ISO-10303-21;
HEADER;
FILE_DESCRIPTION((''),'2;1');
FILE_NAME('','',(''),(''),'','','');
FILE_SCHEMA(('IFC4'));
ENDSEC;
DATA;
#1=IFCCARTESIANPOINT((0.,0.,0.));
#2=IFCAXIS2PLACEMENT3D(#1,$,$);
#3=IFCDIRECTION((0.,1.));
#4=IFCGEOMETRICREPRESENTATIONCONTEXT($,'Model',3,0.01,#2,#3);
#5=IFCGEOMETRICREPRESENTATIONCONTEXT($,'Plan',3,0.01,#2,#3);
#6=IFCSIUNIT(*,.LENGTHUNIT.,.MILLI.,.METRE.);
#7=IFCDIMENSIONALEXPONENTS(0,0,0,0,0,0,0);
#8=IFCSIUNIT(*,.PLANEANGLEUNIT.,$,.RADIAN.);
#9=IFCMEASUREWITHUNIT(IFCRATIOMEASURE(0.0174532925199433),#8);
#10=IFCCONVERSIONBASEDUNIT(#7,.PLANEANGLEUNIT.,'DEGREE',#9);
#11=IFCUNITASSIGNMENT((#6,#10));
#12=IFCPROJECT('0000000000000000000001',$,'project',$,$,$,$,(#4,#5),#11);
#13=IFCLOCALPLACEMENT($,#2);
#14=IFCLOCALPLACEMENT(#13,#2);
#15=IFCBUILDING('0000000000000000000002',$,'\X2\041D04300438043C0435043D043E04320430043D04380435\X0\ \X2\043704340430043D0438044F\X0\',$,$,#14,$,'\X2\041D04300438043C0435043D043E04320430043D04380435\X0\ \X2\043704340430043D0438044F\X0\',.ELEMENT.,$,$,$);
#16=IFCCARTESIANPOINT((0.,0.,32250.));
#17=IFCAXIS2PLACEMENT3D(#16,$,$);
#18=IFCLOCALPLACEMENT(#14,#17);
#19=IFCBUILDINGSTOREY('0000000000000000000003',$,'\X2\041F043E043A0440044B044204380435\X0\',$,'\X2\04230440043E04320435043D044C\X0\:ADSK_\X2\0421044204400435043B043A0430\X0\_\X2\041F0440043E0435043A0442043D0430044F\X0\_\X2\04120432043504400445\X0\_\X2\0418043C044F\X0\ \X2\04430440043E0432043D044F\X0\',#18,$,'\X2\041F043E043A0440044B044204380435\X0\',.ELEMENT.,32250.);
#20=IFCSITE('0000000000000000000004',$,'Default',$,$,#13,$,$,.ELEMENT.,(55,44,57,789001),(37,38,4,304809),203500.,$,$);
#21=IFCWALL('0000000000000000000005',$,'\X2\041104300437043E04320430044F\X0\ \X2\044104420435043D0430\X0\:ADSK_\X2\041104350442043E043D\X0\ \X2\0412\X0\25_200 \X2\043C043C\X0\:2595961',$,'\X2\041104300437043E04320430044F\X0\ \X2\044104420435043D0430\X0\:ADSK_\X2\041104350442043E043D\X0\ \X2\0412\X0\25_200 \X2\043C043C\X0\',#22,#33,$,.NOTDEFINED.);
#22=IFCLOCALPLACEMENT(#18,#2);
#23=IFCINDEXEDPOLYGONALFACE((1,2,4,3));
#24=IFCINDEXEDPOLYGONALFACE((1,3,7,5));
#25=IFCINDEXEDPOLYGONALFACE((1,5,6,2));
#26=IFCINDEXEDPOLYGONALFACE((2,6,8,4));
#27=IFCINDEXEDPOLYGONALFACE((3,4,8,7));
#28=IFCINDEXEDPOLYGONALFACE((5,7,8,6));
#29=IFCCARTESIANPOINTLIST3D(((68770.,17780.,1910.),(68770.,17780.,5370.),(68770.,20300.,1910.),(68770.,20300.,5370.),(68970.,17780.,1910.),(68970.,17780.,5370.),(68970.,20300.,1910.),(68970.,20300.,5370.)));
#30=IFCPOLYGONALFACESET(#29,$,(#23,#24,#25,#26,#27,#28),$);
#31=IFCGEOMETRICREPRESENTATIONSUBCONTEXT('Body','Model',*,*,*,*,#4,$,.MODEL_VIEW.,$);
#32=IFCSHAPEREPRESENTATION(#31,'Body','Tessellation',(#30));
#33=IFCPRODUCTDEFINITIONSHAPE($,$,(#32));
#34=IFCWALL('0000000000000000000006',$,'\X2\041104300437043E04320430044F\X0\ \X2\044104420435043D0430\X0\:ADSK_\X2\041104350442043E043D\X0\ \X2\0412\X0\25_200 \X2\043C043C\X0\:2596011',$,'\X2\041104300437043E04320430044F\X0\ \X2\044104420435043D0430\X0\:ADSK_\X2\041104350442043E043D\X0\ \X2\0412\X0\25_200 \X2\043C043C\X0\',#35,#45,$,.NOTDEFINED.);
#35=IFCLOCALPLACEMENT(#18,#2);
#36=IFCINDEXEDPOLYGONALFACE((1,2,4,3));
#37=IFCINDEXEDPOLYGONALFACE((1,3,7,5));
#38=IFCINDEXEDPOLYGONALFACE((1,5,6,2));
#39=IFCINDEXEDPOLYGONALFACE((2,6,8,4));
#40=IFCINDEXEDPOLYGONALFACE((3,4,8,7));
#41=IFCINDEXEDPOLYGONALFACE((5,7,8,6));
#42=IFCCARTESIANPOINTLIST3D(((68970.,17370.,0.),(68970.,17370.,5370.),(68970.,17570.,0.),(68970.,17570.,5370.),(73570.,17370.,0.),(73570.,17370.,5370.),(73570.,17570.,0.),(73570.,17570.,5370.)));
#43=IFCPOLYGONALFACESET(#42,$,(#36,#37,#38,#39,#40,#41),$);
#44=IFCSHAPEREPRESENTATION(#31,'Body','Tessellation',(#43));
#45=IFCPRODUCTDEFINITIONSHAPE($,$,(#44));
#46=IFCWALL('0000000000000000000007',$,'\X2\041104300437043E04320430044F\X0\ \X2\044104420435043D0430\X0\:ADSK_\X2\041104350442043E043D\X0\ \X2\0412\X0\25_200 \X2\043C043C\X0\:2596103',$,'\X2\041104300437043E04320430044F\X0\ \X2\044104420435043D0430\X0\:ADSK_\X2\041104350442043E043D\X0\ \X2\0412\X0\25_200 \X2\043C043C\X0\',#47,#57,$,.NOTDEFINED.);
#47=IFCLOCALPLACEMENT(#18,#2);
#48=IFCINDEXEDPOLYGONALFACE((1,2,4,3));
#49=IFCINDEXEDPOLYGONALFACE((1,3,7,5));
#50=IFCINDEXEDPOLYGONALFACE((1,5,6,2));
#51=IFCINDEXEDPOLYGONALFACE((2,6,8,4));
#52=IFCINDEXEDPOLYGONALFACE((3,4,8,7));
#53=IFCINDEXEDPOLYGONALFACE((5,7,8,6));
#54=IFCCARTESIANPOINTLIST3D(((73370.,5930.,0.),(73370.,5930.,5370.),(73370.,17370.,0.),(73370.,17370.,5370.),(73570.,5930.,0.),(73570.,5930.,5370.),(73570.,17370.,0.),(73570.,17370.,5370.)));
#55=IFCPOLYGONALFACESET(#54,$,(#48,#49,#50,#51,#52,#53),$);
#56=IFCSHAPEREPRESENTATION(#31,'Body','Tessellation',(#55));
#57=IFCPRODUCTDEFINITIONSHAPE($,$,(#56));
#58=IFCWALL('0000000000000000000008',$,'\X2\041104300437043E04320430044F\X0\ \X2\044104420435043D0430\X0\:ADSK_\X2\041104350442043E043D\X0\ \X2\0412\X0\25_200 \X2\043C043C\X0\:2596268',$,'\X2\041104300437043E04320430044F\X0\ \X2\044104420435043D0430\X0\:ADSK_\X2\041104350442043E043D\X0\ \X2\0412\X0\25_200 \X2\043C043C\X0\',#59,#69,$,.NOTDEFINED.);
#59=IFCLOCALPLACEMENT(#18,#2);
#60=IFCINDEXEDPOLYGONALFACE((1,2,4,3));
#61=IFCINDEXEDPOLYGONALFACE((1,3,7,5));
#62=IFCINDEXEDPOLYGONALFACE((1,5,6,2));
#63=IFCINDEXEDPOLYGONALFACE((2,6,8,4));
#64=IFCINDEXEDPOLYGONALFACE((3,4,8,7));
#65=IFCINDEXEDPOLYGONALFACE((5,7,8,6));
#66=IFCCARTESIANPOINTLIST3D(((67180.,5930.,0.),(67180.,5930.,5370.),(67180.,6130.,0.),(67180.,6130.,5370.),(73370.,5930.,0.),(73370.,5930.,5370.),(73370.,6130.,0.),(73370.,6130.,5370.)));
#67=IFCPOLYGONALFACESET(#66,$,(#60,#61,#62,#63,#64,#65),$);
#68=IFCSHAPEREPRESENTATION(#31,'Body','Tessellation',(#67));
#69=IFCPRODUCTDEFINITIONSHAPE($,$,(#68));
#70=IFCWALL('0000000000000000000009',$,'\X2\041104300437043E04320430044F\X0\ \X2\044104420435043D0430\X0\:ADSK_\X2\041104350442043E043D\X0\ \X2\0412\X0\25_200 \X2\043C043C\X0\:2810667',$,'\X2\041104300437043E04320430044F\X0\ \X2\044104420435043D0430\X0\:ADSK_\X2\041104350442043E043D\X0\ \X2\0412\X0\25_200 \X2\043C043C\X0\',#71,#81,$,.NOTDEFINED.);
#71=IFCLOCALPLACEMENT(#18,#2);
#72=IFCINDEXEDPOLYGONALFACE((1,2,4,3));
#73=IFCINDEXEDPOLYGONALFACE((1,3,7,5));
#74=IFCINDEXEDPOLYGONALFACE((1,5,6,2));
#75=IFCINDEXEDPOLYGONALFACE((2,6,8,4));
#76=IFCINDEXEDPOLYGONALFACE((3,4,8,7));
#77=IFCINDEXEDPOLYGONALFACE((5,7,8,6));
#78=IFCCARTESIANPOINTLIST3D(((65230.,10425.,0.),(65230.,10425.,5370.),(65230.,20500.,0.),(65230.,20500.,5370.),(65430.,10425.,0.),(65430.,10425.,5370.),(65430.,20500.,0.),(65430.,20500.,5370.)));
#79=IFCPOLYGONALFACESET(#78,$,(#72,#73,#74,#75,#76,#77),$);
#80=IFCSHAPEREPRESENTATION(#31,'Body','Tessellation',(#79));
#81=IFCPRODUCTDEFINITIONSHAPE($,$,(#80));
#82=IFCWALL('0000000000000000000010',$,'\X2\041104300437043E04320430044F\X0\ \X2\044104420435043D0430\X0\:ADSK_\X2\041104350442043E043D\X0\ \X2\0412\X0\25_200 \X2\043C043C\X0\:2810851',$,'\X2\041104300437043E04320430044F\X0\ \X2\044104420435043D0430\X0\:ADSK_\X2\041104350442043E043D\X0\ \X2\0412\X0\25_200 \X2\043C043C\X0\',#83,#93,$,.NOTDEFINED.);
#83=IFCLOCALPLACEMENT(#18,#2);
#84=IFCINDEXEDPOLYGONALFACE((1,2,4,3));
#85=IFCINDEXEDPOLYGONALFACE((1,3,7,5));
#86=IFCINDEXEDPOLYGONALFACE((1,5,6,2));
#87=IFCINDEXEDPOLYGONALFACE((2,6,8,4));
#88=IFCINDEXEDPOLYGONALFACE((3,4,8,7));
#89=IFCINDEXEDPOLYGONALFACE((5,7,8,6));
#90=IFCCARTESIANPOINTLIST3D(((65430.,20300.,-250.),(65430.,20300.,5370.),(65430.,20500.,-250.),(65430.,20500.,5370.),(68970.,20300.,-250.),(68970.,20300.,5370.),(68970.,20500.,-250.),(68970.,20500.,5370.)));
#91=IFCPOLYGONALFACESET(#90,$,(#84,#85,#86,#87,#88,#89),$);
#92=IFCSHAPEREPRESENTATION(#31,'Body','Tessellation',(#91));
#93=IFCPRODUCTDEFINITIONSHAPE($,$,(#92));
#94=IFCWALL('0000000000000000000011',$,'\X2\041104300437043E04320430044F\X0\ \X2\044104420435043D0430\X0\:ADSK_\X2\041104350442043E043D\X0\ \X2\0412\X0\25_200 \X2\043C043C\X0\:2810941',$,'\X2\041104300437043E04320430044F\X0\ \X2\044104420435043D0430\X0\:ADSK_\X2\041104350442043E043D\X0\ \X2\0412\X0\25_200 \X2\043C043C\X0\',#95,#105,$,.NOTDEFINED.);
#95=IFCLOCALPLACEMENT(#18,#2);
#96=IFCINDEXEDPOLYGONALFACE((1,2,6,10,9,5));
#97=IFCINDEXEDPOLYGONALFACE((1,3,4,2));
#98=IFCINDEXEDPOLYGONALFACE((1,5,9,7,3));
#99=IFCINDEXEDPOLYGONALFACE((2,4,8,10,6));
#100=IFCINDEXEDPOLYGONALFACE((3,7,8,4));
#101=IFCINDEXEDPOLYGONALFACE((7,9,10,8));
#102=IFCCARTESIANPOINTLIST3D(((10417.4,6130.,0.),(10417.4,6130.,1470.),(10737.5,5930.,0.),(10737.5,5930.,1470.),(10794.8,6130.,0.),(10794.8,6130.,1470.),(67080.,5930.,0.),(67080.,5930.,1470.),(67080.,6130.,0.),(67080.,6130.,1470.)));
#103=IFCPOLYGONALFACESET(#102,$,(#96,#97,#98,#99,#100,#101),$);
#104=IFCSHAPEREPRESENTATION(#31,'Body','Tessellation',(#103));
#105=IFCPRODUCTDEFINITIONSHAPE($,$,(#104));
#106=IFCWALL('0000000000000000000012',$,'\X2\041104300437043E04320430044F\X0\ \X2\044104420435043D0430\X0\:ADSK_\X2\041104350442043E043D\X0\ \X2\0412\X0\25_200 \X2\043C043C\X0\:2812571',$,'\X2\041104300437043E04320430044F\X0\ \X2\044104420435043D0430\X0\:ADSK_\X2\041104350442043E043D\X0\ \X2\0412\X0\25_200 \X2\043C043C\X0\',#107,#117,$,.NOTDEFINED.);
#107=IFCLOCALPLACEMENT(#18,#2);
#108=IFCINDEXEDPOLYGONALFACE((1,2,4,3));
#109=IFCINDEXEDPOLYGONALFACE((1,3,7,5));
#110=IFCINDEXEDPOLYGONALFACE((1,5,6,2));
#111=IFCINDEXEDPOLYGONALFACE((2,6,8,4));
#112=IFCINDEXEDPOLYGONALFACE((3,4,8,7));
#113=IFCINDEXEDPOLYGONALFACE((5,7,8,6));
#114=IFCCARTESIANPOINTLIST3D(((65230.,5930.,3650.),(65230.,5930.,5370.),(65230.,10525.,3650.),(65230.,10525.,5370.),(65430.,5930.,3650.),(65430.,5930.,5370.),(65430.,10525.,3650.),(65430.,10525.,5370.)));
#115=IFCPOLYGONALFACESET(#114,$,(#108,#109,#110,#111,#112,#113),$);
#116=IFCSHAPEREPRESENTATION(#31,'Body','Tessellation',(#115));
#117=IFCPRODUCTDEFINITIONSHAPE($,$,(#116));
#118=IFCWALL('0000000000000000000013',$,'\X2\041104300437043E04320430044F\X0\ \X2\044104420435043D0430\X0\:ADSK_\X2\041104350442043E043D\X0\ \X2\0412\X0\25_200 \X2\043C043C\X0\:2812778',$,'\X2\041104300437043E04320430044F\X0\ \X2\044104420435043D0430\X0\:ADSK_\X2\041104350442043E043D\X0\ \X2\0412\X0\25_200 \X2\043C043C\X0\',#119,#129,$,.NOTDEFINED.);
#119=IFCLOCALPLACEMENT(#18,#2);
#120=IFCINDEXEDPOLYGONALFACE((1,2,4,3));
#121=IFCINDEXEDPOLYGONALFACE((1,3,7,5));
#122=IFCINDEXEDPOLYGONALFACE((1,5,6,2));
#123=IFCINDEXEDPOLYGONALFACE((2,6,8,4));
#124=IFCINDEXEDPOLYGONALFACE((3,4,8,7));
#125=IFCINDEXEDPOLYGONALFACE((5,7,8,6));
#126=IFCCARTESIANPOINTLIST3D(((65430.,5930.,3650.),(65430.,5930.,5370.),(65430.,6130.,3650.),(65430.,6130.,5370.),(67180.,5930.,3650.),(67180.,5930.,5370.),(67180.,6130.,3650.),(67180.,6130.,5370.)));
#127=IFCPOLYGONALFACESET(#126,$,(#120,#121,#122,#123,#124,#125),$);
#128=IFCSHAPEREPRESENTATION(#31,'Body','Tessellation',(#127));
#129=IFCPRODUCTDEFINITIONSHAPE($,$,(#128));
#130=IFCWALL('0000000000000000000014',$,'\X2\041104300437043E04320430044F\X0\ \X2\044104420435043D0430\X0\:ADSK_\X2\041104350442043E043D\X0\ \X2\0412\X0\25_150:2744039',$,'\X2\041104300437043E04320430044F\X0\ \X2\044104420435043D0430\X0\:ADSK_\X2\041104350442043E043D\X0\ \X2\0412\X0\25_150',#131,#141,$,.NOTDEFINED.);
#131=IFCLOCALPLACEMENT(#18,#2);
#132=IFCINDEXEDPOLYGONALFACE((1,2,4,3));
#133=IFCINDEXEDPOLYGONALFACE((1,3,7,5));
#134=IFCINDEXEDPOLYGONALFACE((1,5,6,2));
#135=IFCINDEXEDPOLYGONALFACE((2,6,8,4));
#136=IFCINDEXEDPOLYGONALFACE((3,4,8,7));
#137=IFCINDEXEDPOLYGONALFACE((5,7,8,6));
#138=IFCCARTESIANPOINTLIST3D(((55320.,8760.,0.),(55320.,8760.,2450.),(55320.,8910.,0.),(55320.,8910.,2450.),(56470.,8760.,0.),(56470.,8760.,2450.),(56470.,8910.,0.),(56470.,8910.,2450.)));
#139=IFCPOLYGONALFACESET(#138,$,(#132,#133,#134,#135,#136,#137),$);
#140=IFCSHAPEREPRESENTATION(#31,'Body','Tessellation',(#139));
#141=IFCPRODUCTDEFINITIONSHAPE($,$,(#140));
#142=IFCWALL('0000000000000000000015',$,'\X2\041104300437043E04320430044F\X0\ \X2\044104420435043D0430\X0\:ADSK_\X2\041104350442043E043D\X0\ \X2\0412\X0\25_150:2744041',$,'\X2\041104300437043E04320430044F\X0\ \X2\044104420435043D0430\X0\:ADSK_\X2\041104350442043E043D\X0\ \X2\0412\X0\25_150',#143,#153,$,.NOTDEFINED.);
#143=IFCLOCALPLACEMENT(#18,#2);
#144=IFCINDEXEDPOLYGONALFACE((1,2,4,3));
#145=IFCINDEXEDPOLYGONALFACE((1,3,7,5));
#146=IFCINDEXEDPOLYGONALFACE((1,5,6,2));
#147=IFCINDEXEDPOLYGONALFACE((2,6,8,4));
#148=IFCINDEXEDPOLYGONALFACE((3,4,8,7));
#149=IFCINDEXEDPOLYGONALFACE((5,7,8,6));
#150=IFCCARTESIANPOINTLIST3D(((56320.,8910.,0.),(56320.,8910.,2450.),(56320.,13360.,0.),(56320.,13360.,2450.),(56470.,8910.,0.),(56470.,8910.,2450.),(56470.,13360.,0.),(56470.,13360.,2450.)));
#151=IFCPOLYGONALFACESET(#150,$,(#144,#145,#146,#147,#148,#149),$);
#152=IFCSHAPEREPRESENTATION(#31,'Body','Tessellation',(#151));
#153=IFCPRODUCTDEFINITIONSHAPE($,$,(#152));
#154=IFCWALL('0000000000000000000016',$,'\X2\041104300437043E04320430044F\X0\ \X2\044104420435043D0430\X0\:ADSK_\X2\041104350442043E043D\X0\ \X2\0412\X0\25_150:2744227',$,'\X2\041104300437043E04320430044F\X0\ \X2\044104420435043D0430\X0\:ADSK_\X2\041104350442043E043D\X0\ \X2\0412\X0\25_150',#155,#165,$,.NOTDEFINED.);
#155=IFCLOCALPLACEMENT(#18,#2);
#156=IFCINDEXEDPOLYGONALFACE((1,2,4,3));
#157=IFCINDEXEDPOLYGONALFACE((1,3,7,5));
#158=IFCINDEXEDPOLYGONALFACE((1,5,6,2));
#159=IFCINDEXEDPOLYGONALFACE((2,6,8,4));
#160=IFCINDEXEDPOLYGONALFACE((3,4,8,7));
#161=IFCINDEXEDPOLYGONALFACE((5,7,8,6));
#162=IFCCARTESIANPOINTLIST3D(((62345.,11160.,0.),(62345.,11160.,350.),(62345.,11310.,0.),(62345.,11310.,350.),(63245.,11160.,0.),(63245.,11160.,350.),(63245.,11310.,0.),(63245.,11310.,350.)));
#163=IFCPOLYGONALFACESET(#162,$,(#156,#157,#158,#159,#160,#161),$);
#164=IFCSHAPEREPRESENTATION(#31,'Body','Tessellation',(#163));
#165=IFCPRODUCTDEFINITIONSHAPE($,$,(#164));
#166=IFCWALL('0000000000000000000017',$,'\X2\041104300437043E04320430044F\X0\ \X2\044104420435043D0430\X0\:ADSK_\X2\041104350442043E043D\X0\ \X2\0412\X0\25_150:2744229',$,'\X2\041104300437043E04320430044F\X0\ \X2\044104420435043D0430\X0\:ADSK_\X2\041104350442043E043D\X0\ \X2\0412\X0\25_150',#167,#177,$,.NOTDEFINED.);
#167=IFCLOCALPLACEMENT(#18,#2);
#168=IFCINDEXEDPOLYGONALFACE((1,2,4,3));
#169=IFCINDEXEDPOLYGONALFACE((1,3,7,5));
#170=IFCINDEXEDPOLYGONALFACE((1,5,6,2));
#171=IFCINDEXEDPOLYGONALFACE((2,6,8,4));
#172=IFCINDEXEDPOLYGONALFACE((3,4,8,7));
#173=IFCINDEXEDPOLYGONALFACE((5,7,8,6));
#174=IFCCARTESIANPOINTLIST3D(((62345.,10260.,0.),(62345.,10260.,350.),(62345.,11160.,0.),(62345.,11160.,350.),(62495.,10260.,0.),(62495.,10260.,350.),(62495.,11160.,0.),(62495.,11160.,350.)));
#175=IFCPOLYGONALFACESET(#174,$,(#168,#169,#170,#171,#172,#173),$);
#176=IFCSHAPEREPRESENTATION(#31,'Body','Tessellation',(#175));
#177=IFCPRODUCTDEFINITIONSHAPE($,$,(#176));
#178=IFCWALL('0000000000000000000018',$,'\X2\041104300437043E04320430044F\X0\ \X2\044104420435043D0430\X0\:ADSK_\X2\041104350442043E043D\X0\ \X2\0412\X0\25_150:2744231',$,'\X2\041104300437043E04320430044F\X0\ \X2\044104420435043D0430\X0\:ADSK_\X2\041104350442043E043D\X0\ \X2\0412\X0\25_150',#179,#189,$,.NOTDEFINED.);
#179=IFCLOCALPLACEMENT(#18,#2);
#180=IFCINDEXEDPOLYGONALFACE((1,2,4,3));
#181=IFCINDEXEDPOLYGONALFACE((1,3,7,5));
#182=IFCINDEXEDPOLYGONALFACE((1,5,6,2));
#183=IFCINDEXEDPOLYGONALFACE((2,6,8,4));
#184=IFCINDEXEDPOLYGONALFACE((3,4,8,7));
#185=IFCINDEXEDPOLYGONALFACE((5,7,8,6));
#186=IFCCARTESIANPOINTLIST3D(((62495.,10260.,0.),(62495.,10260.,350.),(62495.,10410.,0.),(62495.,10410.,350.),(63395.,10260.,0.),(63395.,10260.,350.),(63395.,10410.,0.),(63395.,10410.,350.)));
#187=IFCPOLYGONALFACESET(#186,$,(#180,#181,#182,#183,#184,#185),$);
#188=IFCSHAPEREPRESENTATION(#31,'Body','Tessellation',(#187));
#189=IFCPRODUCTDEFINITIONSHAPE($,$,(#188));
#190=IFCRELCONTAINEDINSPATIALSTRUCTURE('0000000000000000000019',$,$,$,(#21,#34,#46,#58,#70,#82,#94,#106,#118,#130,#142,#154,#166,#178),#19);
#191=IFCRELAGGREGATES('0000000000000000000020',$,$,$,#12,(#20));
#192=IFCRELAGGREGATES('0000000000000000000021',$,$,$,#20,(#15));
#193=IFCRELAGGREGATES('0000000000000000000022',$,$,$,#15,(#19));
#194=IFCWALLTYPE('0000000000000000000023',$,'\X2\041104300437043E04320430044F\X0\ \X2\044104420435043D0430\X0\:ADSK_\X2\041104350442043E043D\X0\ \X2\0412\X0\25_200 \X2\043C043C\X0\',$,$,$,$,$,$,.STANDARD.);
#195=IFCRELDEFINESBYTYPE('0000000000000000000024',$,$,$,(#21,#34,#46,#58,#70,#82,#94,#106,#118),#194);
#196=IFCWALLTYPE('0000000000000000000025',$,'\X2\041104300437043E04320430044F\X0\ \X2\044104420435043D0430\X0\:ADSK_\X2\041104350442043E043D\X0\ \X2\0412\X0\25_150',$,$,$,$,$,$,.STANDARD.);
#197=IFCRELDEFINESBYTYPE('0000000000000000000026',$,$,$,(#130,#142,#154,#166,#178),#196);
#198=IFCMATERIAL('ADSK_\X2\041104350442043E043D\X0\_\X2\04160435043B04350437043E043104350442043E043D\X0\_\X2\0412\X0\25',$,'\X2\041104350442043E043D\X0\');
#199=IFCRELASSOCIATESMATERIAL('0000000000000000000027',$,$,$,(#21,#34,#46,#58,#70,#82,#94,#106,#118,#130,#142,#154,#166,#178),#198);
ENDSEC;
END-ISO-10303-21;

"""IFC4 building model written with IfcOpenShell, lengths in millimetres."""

from ifc_helpers import new_model, entity, si_unit, converted_unit, direction, frame, origin, place, context, subcontext, project, spatial, indexed_curve, outline, extrude, material, type_object, element, save


model = new_model("IFC4")

# Units and contexts
model_context = context("Model", 3, precision=0.01, world=origin(), true_north=direction((0.0, 1.0)))
plan_context = context("Plan", 3, precision=0.01, world=origin(), true_north=direction((0.0, 1.0)))
body_context = subcontext(model_context, "Body", "Model", "MODEL_VIEW")
ifc_project = project(units=[si_unit("LENGTHUNIT", "METRE", prefix="MILLI"), converted_unit("PLANEANGLEUNIT", "DEGREE", entity("IfcRatioMeasure", 0.0174532925199433), si_unit("PLANEANGLEUNIT", "RADIAN"), dimensions=[0, 0, 0, 0, 0, 0, 0])], contexts=[model_context, plan_context])

# Site, building, storey
site_placement = place(None, origin())
site = spatial("IfcSite", under=ifc_project, at=site_placement, Name="Default", CompositionType="ELEMENT", RefLatitude=(55, 44, 57, 789001), RefLongitude=(37, 38, 4, 304809), RefElevation=203500.0)
building_placement = place(site_placement, origin())
building = spatial("IfcBuilding", under=site, at=building_placement, Name="Наименование здания", LongName="Наименование здания", CompositionType="ELEMENT")
storey_placement = place(building_placement, frame((0.0, 0.0, 32250.0)))
storey = spatial("IfcBuildingStorey", under=building, at=storey_placement, Name="Покрытие", ObjectType="Уровень:ADSK_Стрелка_Проектная_Вверх_Имя уровня", LongName="Покрытие", CompositionType="ELEMENT", Elevation=32250.0)

# Walls
ifc_material = material(Name="ADSK_Бетон_Железобетон_В25", Category="Бетон")
wall_type_1 = type_object("IfcWallType", Name="Базовая стена:ADSK_Бетон В25_200 мм", PredefinedType="STANDARD")
wall_1_placement = place(storey_placement, frame((68870.0, 20300.0, 1910.0), z_axis=(0.0, 0.0, 1.0), x_axis=(0.0, -1.0, 0.0)))
element("IfcWall", 1, at=wall_1_placement, inside=storey, type_object=wall_type_1, material=ifc_material, Name="Базовая стена:ADSK_Бетон В25_200 мм:2595961", ObjectType="Базовая стена:ADSK_Бетон В25_200 мм", PredefinedType="NOTDEFINED", context=body_context, shape_type="SweptSolid", body=[
    extrude(outline(indexed_curve([(2520.0, 100.0), (0.0, 100.0), (0.0, -100.0), (2520.0, -100.0), (2520.0, 100.0)], self_intersect=False)), origin(), (0.0, 0.0, 1.0), 3460.0),
])
wall_2_placement = place(storey_placement, frame((68970.0, 17470.0, 0.0)))
element("IfcWall", 2, at=wall_2_placement, inside=storey, type_object=wall_type_1, material=ifc_material, Name="Базовая стена:ADSK_Бетон В25_200 мм:2596011", ObjectType="Базовая стена:ADSK_Бетон В25_200 мм", PredefinedType="NOTDEFINED", context=body_context, shape_type="SweptSolid", body=[
    extrude(outline(indexed_curve([(4600.0, 100.0), (0.0, 100.0), (0.0, -100.0), (4600.0, -100.0), (4600.0, 100.0)], self_intersect=False)), origin(), (0.0, 0.0, 1.0), 5370.0),
])
wall_3_placement = place(storey_placement, frame((73470.0, 17370.0, 0.0), z_axis=(0.0, 0.0, 1.0), x_axis=(0.0, -1.0, 0.0)))
element("IfcWall", 3, at=wall_3_placement, inside=storey, type_object=wall_type_1, material=ifc_material, Name="Базовая стена:ADSK_Бетон В25_200 мм:2596103", ObjectType="Базовая стена:ADSK_Бетон В25_200 мм", PredefinedType="NOTDEFINED", context=body_context, shape_type="SweptSolid", body=[
    extrude(outline(indexed_curve([(11440.0, 100.0), (0.0, 100.0), (0.0, -100.0), (11440.0, -100.0), (11440.0, 100.0)], self_intersect=False)), origin(), (0.0, 0.0, 1.0), 5370.0),
])
wall_4_placement = place(storey_placement, frame((73370.0, 6030.0, 0.0), z_axis=(0.0, 0.0, 1.0), x_axis=(-1.0, 0.0, 0.0)))
element("IfcWall", 4, at=wall_4_placement, inside=storey, type_object=wall_type_1, material=ifc_material, Name="Базовая стена:ADSK_Бетон В25_200 мм:2596268", ObjectType="Базовая стена:ADSK_Бетон В25_200 мм", PredefinedType="NOTDEFINED", context=body_context, shape_type="SweptSolid", body=[
    extrude(outline(indexed_curve([(6190.0, 100.0), (0.0, 100.0), (0.0, -100.0), (6190.0, -100.0), (6190.0, 100.0)], self_intersect=False)), origin(), (0.0, 0.0, 1.0), 5370.0),
])
wall_5_placement = place(storey_placement, frame((65330.0, 20500.0, 0.0), z_axis=(0.0, 0.0, 1.0), x_axis=(0.0, -1.0, 0.0)))
element("IfcWall", 5, at=wall_5_placement, inside=storey, type_object=wall_type_1, material=ifc_material, Name="Базовая стена:ADSK_Бетон В25_200 мм:2810667", ObjectType="Базовая стена:ADSK_Бетон В25_200 мм", PredefinedType="NOTDEFINED", context=body_context, shape_type="SweptSolid", body=[
    extrude(outline(indexed_curve([(10075.0, 100.0), (0.0, 100.0), (0.0, -100.0), (10075.0, -100.0), (10075.0, 100.0)], self_intersect=False)), origin(), (0.0, 0.0, 1.0), 5370.0),
])
wall_6_placement = place(storey_placement, frame((65430.0, 20400.0, -250.0)))
element("IfcWall", 6, at=wall_6_placement, inside=storey, type_object=wall_type_1, material=ifc_material, Name="Базовая стена:ADSK_Бетон В25_200 мм:2810851", ObjectType="Базовая стена:ADSK_Бетон В25_200 мм", PredefinedType="NOTDEFINED", context=body_context, shape_type="SweptSolid", body=[
    extrude(outline(indexed_curve([(3540.0, 100.0), (0.0, 100.0), (0.0, -100.0), (3540.0, -100.0), (3540.0, 100.0)], self_intersect=False)), origin(), (0.0, 0.0, 1.0), 5620.0),
])
wall_7_placement = place(storey_placement, frame((67080.0, 6030.0, 0.0), z_axis=(0.0, 0.0, 1.0), x_axis=(-1.0, 0.0, 0.0)))
element("IfcWall", 7, at=wall_7_placement, inside=storey, type_object=wall_type_1, material=ifc_material, Name="Базовая стена:ADSK_Бетон В25_200 мм:2810941", ObjectType="Базовая стена:ADSK_Бетон В25_200 мм", PredefinedType="NOTDEFINED", context=body_context, shape_type="SweptSolid", body=[
    extrude(outline(indexed_curve([(56662.6, -100.0), (56342.5, 100.0), (0.0, 100.0), (0.0, -100.0), (56285.2, -100.0), (56662.6, -100.0)], self_intersect=False)), origin(), (0.0, 0.0, 1.0), 1470.0),
])
wall_8_placement = place(storey_placement, frame((65330.0, 10525.0, 3650.0), z_axis=(0.0, 0.0, 1.0), x_axis=(0.0, -1.0, 0.0)))
element("IfcWall", 8, at=wall_8_placement, inside=storey, type_object=wall_type_1, material=ifc_material, Name="Базовая стена:ADSK_Бетон В25_200 мм:2812571", ObjectType="Базовая стена:ADSK_Бетон В25_200 мм", PredefinedType="NOTDEFINED", context=body_context, shape_type="SweptSolid", body=[
    extrude(outline(indexed_curve([(4595.0, 100.0), (0.0, 100.0), (0.0, -100.0), (4595.0, -100.0), (4595.0, 100.0)], self_intersect=False)), origin(), (0.0, 0.0, 1.0), 1720.0),
])
wall_9_placement = place(storey_placement, frame((65430.0, 6030.0, 3650.0)))
element("IfcWall", 9, at=wall_9_placement, inside=storey, type_object=wall_type_1, material=ifc_material, Name="Базовая стена:ADSK_Бетон В25_200 мм:2812778", ObjectType="Базовая стена:ADSK_Бетон В25_200 мм", PredefinedType="NOTDEFINED", context=body_context, shape_type="SweptSolid", body=[
    extrude(outline(indexed_curve([(1750.0, 100.0), (0.0, 100.0), (0.0, -100.0), (1750.0, -100.0), (1750.0, 100.0)], self_intersect=False)), origin(), (0.0, 0.0, 1.0), 1720.0),
])
wall_type_2 = type_object("IfcWallType", Name="Базовая стена:ADSK_Бетон В25_150", PredefinedType="STANDARD")
wall_10_placement = place(storey_placement, frame((56470.0, 8835.0, 0.0), z_axis=(0.0, 0.0, 1.0), x_axis=(-1.0, 0.0, 0.0)))
element("IfcWall", 10, at=wall_10_placement, inside=storey, type_object=wall_type_2, material=ifc_material, Name="Базовая стена:ADSK_Бетон В25_150:2744039", ObjectType="Базовая стена:ADSK_Бетон В25_150", PredefinedType="NOTDEFINED", context=body_context, shape_type="SweptSolid", body=[
    extrude(outline(indexed_curve([(1150.0, 75.0), (0.0, 75.0), (0.0, -75.0), (1150.0, -75.0), (1150.0, 75.0)], self_intersect=False)), origin(), (0.0, 0.0, 1.0), 2450.0),
])
wall_11_placement = place(storey_placement, frame((56395.0, 13360.0, 0.0), z_axis=(0.0, 0.0, 1.0), x_axis=(0.0, -1.0, 0.0)))
element("IfcWall", 11, at=wall_11_placement, inside=storey, type_object=wall_type_2, material=ifc_material, Name="Базовая стена:ADSK_Бетон В25_150:2744041", ObjectType="Базовая стена:ADSK_Бетон В25_150", PredefinedType="NOTDEFINED", context=body_context, shape_type="SweptSolid", body=[
    extrude(outline(indexed_curve([(4450.0, 75.0), (0.0, 75.0), (0.0, -75.0), (4450.0, -75.0), (4450.0, 75.0)], self_intersect=False)), origin(), (0.0, 0.0, 1.0), 2450.0),
])
wall_12_placement = place(storey_placement, frame((62345.0, 11235.0, 0.0)))
element("IfcWall", 12, at=wall_12_placement, inside=storey, type_object=wall_type_2, material=ifc_material, Name="Базовая стена:ADSK_Бетон В25_150:2744227", ObjectType="Базовая стена:ADSK_Бетон В25_150", PredefinedType="NOTDEFINED", context=body_context, shape_type="SweptSolid", body=[
    extrude(outline(indexed_curve([(900.0, 75.0), (0.0, 75.0), (0.0, -75.0), (900.0, -75.0), (900.0, 75.0)], self_intersect=False)), origin(), (0.0, 0.0, 1.0), 350.0),
])
wall_13_placement = place(storey_placement, frame((62420.0, 10260.0, 0.0), z_axis=(0.0, 0.0, 1.0), x_axis=(0.0, 1.0, 0.0)))
element("IfcWall", 13, at=wall_13_placement, inside=storey, type_object=wall_type_2, material=ifc_material, Name="Базовая стена:ADSK_Бетон В25_150:2744229", ObjectType="Базовая стена:ADSK_Бетон В25_150", PredefinedType="NOTDEFINED", context=body_context, shape_type="SweptSolid", body=[
    extrude(outline(indexed_curve([(900.0, 75.0), (0.0, 75.0), (0.0, -75.0), (900.0, -75.0), (900.0, 75.0)], self_intersect=False)), origin(), (0.0, 0.0, 1.0), 350.0),
])
wall_14_placement = place(storey_placement, frame((63395.0, 10335.0, 0.0), z_axis=(0.0, 0.0, 1.0), x_axis=(-1.0, 0.0, 0.0)))
element("IfcWall", 14, at=wall_14_placement, inside=storey, type_object=wall_type_2, material=ifc_material, Name="Базовая стена:ADSK_Бетон В25_150:2744231", ObjectType="Базовая стена:ADSK_Бетон В25_150", PredefinedType="NOTDEFINED", context=body_context, shape_type="SweptSolid", body=[
    extrude(outline(indexed_curve([(900.0, 75.0), (0.0, 75.0), (0.0, -75.0), (900.0, -75.0), (900.0, 75.0)], self_intersect=False)), origin(), (0.0, 0.0, 1.0), 350.0),
])

save(model, "model.ifc")
